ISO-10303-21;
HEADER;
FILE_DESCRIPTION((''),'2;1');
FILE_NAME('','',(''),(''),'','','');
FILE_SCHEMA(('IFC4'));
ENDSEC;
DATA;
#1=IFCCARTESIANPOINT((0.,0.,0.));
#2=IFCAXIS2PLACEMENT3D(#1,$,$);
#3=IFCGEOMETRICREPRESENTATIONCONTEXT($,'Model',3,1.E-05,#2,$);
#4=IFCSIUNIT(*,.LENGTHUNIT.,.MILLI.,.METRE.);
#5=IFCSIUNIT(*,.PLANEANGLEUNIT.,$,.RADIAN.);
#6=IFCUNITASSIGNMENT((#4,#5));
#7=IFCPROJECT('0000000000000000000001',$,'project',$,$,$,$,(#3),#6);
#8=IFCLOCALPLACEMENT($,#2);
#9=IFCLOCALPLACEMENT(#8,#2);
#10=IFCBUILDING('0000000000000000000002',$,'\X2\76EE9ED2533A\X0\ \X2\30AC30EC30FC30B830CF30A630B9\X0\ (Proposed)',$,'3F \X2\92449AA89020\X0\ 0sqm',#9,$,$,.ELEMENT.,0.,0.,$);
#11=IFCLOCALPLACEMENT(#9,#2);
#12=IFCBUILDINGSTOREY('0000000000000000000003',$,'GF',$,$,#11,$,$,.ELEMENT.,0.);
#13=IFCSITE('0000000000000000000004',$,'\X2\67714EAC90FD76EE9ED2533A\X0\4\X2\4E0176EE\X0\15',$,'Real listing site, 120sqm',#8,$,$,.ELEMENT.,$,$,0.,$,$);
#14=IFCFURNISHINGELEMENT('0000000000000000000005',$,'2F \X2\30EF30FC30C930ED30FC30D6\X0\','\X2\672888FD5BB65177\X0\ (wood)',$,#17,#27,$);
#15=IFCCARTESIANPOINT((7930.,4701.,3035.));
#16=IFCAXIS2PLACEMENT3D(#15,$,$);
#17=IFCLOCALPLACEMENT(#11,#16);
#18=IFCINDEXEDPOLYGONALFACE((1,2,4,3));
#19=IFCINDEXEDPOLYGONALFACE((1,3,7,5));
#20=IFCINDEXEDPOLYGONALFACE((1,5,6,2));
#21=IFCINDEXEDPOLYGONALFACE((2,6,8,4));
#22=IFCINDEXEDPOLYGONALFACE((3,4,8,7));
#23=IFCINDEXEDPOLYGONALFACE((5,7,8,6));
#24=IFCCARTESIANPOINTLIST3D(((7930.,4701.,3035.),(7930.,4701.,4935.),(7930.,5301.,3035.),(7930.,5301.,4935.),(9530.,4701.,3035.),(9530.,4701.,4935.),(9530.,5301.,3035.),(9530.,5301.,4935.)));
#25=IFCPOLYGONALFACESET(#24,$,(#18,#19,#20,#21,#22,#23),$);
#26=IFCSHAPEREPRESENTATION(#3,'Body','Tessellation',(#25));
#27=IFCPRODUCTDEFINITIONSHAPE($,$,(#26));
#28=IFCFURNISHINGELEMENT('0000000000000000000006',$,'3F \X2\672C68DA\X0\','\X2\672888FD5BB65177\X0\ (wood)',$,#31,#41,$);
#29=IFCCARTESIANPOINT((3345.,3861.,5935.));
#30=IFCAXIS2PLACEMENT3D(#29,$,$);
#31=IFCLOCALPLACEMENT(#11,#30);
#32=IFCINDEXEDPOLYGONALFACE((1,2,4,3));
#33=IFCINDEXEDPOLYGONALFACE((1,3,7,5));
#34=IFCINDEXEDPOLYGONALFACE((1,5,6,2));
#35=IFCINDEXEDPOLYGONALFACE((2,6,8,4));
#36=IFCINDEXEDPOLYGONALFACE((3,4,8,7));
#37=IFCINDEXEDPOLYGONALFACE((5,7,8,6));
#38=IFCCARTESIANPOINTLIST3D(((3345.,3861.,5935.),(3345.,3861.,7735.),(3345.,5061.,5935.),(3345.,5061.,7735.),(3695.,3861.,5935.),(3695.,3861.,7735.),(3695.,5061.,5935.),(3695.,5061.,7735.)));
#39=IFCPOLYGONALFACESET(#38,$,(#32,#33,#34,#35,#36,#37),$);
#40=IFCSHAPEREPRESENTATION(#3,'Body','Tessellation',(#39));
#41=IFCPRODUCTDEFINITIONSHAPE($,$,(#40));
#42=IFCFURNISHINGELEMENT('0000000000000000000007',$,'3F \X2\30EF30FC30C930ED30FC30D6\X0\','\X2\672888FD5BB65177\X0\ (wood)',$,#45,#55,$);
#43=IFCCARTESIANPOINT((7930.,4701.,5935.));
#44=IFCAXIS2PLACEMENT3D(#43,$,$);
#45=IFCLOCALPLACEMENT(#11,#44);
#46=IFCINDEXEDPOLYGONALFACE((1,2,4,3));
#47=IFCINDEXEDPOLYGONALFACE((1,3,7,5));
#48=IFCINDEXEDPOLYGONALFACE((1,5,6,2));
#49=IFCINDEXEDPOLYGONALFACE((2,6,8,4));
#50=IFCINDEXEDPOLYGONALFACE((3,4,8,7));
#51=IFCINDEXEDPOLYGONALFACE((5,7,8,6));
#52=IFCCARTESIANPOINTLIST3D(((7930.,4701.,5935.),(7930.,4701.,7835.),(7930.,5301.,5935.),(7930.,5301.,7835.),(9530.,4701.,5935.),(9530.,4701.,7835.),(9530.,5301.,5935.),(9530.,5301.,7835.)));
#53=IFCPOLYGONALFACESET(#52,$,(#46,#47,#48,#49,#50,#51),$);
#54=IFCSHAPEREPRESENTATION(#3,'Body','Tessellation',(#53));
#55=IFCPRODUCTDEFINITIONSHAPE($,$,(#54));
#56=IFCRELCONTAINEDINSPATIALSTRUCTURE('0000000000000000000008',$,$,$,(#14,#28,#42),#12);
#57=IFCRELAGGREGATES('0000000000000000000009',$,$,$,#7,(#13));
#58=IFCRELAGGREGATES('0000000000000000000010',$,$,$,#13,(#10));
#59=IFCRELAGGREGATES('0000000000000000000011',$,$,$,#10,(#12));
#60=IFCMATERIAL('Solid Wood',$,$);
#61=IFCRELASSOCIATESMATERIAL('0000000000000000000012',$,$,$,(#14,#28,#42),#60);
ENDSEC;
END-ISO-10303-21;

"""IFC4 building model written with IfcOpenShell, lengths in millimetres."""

from ifc_helpers import new_model, si_unit, frame, frame_2d, origin, place, context, project, spatial, rectangle, extrude, material, element, save


model = new_model("IFC4")

# Units and contexts
model_context = context("Model", 3, precision=1e-05, world=origin())
ifc_project = project(units=[si_unit("LENGTHUNIT", "METRE", prefix="MILLI"), si_unit("PLANEANGLEUNIT", "RADIAN")], contexts=[model_context])

# Site, building, storey
site_placement = place(None, origin())
site = spatial("IfcSite", under=ifc_project, at=site_placement, Name="東京都目黒区4丁目15", ObjectType="Real listing site, 120sqm", CompositionType="ELEMENT", RefElevation=0.0)
building_placement = place(site_placement, origin())
building = spatial("IfcBuilding", under=site, at=building_placement, Name="目黒区 ガレージハウス (Proposed)", ObjectType="3F 鉄骨造 0sqm", CompositionType="ELEMENT", ElevationOfRefHeight=0.0, ElevationOfTerrain=0.0)
storey_placement = place(building_placement, origin())
storey = spatial("IfcBuildingStorey", under=building, at=storey_placement, Name="GF", CompositionType="ELEMENT", Elevation=0.0)

# Shared definitions
ifc_material_1 = material(Name="Solid Wood")

# Furnishing elements
furnishing_1_placement = place(storey_placement, frame((7930.0, 4701.0, 3035.0)))
element("IfcFurnishingElement", 1, at=furnishing_1_placement, inside=storey, material=ifc_material_1, Name="2F ワードローブ", Description="木製家具 (wood)", context=model_context, shape_type="SweptSolid", body=[
    extrude(rectangle(XDim=1600.0, YDim=600.0, at=frame_2d((800.0, 300.0))), frame((7930.0, 4701.0, 3035.0)), (0.0, 0.0, 1.0), 1900.0),
])
furnishing_2_placement = place(storey_placement, frame((3345.0, 3861.0, 5935.0)))
element("IfcFurnishingElement", 2, at=furnishing_2_placement, inside=storey, material=ifc_material_1, Name="3F 本棚", Description="木製家具 (wood)", context=model_context, shape_type="SweptSolid", body=[
    extrude(rectangle(XDim=350.0, YDim=1200.0, at=frame_2d((175.0, 600.0))), frame((3345.0, 3861.0, 5935.0)), (0.0, 0.0, 1.0), 1800.0),
])
furnishing_3_placement = place(storey_placement, frame((7930.0, 4701.0, 5935.0)))
element("IfcFurnishingElement", 3, at=furnishing_3_placement, inside=storey, material=ifc_material_1, Name="3F ワードローブ", Description="木製家具 (wood)", context=model_context, shape_type="SweptSolid", body=[
    extrude(rectangle(XDim=1600.0, YDim=600.0, at=frame_2d((800.0, 300.0))), frame((7930.0, 4701.0, 5935.0)), (0.0, 0.0, 1.0), 1900.0),
])

save(model, "model.ifc")
